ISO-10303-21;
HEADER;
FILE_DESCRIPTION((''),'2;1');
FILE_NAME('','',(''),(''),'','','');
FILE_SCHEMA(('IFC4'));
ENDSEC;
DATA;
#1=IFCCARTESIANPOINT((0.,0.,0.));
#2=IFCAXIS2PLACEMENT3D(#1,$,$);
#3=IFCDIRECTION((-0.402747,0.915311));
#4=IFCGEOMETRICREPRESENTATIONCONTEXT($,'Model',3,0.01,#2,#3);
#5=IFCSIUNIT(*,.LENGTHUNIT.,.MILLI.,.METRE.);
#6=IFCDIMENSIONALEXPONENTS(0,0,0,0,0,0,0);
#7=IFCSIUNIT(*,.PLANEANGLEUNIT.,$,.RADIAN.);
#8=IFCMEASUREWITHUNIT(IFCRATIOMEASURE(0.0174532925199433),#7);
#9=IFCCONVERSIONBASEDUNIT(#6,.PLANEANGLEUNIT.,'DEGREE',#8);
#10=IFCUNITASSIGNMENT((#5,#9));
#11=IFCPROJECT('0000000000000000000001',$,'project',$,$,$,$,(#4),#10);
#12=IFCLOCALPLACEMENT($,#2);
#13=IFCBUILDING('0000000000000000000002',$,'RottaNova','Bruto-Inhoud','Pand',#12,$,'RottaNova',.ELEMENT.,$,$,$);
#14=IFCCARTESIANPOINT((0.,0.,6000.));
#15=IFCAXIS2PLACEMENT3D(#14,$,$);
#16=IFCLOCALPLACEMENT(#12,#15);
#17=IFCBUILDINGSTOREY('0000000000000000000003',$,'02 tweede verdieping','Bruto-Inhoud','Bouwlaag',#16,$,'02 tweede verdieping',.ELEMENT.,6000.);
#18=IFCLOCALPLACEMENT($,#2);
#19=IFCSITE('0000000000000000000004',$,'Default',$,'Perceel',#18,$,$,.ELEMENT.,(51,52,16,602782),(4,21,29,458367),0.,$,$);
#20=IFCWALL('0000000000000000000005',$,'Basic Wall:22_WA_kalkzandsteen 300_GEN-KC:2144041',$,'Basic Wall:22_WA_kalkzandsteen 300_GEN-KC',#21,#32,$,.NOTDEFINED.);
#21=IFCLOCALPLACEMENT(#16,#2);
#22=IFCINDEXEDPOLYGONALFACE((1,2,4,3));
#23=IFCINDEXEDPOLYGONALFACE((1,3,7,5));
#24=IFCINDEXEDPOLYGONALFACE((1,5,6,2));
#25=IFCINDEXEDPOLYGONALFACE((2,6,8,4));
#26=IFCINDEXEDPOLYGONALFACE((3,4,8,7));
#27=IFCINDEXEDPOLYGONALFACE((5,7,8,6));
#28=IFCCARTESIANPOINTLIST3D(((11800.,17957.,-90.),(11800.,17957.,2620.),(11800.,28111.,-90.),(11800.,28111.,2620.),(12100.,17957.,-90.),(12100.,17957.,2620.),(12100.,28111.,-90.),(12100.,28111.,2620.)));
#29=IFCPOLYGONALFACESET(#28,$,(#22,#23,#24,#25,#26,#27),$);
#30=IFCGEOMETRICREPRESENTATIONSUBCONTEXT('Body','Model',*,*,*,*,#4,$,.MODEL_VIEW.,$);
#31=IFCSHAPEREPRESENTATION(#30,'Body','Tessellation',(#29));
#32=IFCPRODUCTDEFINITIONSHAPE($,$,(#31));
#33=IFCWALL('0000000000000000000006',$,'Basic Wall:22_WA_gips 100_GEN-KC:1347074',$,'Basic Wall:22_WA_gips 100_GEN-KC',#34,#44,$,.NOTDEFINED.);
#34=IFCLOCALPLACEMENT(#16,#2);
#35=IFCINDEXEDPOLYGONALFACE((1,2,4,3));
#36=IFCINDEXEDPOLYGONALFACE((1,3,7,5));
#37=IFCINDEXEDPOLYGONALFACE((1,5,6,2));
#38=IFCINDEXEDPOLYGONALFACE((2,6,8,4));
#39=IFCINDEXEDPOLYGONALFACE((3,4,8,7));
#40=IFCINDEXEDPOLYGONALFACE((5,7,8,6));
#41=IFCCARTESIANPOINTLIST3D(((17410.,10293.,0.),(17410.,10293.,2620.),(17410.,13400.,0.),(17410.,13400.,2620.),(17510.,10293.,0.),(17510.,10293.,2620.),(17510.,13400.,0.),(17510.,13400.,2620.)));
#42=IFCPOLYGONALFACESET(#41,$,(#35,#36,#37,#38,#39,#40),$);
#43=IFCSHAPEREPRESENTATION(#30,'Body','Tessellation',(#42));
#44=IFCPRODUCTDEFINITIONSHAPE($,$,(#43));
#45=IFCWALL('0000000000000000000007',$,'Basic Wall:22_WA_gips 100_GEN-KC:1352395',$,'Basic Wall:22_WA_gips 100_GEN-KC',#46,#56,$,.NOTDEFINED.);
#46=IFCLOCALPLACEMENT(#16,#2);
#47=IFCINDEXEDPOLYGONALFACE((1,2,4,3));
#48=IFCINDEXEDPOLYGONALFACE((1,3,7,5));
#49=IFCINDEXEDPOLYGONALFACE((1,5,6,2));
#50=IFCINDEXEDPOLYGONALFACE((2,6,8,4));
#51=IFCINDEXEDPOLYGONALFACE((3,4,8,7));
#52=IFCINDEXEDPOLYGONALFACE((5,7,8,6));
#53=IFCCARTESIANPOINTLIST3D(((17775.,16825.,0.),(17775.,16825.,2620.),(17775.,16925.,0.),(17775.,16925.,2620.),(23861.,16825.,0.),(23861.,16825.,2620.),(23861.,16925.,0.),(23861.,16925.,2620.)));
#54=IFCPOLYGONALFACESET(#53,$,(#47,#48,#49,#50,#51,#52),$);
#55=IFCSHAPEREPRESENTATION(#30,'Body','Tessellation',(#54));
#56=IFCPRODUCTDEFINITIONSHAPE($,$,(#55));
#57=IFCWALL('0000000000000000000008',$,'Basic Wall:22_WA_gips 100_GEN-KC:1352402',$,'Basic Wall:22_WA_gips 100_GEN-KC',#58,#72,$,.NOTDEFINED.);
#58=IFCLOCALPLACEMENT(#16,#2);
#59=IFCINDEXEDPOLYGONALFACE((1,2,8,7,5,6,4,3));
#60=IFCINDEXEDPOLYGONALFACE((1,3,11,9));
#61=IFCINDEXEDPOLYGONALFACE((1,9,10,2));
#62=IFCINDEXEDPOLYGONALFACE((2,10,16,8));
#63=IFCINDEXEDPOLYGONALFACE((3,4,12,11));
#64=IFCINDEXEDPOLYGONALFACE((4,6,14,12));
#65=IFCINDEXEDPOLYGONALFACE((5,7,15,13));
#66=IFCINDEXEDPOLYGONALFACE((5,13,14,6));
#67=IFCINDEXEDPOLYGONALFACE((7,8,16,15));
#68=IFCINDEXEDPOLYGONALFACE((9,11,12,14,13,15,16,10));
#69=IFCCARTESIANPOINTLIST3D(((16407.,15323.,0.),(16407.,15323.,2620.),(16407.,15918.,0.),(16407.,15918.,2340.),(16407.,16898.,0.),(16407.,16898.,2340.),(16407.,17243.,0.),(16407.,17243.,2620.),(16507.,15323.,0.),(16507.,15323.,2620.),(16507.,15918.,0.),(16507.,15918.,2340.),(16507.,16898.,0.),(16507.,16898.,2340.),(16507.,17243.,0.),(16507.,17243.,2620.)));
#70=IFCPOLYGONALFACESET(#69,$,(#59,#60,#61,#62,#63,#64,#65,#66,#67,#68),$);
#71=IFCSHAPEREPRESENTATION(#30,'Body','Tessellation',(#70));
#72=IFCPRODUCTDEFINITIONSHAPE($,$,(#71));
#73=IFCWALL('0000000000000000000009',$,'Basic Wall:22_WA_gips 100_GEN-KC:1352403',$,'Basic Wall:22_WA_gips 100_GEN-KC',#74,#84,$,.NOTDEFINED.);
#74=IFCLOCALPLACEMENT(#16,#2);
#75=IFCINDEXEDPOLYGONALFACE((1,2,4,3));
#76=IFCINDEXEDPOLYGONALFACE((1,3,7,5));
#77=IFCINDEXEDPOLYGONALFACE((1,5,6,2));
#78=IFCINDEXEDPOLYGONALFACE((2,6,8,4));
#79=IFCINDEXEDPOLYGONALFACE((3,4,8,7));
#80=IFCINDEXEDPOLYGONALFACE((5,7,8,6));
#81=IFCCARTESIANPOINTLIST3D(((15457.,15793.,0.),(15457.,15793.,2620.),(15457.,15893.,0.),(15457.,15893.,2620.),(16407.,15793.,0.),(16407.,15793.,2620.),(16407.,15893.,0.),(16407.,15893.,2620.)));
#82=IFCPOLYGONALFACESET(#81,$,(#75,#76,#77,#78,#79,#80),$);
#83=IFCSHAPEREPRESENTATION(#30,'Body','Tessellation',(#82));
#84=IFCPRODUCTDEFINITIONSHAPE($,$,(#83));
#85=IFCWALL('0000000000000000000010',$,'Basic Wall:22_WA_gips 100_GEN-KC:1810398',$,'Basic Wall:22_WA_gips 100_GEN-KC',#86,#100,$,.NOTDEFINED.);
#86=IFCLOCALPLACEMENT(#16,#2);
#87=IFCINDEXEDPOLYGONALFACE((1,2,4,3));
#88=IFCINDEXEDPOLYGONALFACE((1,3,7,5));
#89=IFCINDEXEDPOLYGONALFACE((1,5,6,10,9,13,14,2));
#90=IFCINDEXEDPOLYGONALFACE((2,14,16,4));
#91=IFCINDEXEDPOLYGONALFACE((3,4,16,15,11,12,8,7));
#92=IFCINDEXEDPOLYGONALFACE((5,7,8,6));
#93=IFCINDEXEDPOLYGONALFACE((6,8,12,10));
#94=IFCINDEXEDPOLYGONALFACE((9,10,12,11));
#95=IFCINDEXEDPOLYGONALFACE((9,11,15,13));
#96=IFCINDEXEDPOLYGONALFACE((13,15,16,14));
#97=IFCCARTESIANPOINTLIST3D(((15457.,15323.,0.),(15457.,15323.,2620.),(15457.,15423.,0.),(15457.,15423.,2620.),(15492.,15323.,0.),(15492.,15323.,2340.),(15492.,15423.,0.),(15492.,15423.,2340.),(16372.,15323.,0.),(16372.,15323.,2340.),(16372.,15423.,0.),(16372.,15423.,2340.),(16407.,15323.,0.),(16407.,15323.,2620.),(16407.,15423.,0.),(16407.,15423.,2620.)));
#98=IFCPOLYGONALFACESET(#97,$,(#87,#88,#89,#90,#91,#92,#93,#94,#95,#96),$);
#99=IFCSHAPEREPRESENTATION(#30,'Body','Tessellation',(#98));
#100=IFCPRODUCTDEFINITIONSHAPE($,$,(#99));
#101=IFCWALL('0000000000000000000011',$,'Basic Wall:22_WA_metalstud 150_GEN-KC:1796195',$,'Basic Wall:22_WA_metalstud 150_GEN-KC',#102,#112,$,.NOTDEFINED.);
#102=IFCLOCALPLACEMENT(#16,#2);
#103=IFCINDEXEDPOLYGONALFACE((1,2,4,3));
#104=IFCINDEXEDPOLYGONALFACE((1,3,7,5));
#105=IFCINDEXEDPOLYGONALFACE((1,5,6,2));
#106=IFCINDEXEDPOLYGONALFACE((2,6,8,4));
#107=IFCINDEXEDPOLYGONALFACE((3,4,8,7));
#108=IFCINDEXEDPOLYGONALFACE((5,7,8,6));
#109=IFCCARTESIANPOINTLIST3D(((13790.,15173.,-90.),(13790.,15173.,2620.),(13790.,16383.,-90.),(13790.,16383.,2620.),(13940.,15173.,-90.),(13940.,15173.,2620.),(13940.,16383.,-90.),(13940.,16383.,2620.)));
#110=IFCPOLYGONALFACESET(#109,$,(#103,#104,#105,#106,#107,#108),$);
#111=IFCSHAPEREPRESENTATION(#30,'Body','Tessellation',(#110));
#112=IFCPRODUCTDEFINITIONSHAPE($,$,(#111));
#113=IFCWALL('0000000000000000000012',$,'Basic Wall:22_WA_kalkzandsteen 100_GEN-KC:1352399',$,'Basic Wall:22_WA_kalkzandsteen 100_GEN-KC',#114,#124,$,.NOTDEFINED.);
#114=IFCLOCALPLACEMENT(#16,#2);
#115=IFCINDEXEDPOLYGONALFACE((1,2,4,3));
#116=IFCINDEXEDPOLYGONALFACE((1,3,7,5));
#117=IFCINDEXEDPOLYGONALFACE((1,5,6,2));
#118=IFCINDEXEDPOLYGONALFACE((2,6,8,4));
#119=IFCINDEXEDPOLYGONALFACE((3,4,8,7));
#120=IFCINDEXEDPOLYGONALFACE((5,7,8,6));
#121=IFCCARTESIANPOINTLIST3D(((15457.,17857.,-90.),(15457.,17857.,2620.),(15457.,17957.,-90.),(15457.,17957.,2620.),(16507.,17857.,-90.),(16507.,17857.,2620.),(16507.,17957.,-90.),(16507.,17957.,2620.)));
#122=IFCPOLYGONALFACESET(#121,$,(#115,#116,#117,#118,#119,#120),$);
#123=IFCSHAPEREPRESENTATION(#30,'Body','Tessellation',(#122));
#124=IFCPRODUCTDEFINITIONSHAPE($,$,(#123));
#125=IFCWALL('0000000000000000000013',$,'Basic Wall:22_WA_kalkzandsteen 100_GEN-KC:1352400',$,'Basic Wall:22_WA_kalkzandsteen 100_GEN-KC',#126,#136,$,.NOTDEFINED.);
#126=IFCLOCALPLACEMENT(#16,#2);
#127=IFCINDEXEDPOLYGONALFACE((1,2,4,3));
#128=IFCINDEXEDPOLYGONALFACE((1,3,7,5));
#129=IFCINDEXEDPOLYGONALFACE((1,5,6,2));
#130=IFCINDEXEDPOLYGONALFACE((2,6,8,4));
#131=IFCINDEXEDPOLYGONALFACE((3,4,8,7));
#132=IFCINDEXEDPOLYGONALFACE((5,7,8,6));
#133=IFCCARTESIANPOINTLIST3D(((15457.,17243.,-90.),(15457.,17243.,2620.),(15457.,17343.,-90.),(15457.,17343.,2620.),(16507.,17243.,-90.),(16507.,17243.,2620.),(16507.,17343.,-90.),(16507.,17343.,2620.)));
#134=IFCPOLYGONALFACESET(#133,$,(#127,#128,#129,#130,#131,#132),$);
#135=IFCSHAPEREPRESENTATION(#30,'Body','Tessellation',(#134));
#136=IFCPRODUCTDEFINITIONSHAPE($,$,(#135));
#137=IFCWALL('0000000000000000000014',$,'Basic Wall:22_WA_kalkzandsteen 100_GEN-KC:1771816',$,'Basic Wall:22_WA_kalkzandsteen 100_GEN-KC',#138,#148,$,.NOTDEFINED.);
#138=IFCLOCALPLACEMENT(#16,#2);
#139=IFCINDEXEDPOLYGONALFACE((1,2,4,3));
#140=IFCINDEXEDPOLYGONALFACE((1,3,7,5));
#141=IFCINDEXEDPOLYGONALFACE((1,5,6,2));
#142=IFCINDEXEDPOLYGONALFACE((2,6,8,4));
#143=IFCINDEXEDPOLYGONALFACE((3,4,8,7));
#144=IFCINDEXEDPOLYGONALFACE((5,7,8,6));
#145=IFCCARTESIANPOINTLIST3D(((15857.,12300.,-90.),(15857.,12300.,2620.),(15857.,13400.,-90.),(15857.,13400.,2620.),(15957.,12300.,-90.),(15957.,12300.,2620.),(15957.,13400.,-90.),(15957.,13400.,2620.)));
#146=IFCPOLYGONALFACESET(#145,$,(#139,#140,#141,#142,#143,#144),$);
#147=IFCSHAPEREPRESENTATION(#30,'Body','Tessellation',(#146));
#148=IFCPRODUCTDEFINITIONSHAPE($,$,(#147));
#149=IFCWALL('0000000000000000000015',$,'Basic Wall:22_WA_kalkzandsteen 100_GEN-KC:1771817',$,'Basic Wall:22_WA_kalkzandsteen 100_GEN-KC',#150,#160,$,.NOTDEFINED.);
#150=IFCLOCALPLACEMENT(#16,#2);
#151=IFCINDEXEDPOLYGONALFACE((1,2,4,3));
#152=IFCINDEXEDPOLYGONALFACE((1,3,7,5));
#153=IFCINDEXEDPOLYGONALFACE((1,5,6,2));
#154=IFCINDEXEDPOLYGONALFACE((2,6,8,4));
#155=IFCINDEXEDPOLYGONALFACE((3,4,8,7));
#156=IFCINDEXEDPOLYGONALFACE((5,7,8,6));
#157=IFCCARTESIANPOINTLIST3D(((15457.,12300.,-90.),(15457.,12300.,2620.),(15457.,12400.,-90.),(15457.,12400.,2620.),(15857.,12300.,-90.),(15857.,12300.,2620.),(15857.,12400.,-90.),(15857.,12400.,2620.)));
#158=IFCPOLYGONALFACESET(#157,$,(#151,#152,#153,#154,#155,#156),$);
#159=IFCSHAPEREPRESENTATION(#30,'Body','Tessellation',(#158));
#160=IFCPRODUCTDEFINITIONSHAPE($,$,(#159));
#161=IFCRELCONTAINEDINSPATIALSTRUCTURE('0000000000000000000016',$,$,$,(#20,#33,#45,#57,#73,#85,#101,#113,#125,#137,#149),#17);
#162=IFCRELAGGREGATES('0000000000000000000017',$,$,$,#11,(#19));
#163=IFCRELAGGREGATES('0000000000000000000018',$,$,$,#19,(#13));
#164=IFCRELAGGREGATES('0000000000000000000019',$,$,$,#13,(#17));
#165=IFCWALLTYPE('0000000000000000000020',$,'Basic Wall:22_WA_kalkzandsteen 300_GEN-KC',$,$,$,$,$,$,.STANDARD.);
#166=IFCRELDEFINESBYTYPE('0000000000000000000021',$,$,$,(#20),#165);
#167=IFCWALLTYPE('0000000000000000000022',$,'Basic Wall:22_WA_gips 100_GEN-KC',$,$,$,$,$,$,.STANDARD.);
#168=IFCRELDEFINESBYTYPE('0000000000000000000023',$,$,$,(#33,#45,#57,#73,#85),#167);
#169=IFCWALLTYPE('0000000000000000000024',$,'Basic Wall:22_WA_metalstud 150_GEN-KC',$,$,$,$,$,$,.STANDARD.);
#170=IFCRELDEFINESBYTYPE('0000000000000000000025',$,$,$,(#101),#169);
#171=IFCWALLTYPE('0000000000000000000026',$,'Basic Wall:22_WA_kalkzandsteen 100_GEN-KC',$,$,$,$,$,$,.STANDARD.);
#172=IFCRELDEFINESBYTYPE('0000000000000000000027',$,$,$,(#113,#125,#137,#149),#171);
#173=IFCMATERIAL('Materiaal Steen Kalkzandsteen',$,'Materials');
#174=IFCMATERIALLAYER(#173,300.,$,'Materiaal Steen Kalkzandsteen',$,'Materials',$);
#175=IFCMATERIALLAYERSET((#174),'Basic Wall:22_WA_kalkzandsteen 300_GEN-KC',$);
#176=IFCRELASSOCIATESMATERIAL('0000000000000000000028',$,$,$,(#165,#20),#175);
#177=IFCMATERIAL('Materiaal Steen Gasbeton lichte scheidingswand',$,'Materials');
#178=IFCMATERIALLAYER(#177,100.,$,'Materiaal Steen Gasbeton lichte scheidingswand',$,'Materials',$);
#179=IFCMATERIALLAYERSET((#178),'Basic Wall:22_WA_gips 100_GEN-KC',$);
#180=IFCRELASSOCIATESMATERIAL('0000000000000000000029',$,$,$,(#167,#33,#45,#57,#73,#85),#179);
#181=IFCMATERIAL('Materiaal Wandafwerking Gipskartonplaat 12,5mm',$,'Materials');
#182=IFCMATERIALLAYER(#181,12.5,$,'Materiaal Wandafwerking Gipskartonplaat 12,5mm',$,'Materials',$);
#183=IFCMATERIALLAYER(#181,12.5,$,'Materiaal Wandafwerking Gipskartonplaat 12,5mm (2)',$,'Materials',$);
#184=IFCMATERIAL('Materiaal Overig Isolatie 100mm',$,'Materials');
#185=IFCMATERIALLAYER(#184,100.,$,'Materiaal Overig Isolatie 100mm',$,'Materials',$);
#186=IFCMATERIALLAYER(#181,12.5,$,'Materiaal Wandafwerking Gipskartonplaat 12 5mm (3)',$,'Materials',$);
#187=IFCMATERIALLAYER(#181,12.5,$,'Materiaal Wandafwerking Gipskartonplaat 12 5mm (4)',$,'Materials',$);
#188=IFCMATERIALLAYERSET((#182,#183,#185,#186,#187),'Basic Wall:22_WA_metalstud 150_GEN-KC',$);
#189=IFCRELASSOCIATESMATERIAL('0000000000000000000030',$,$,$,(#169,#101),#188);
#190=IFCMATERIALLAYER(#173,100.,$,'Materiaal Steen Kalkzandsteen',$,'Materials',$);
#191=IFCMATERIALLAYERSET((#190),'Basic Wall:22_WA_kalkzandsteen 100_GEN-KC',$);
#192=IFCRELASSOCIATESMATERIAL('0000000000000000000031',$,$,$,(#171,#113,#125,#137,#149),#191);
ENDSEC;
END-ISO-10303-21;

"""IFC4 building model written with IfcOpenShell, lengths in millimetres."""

from ifc_helpers import new_model, entity, si_unit, converted_unit, direction, frame, frame_2d, origin, place, context, subcontext, project, spatial, rectangle, extrude, material, layer, layer_set, type_object, element, save


model = new_model("IFC4")

# Units and contexts
model_context = context("Model", 3, precision=0.01, world=origin(), true_north=direction((-0.402747, 0.915311)))
body_context = subcontext(model_context, "Body", "Model", "MODEL_VIEW")
ifc_project = project(units=[si_unit("LENGTHUNIT", "METRE", prefix="MILLI"), converted_unit("PLANEANGLEUNIT", "DEGREE", entity("IfcRatioMeasure", 0.0174532925199433), si_unit("PLANEANGLEUNIT", "RADIAN"), dimensions=[0, 0, 0, 0, 0, 0, 0])], contexts=[model_context])

# Site, building, storey
site_placement = place(None, origin())
site = spatial("IfcSite", under=ifc_project, at=site_placement, Name="Default", ObjectType="Perceel", CompositionType="ELEMENT", RefLatitude=(51, 52, 16, 602782), RefLongitude=(4, 21, 29, 458367), RefElevation=0.0)
building_placement = place(None, origin())
building = spatial("IfcBuilding", under=site, at=building_placement, Name="RottaNova", Description="Bruto-Inhoud", ObjectType="Pand", LongName="RottaNova", CompositionType="ELEMENT")
storey_placement = place(building_placement, frame((0.0, 0.0, 6000.0)))
storey = spatial("IfcBuildingStorey", under=building, at=storey_placement, Name="02 tweede verdieping", Description="Bruto-Inhoud", ObjectType="Bouwlaag", LongName="02 tweede verdieping", CompositionType="ELEMENT", Elevation=6000.0)

# Walls
ifc_material_1 = material(Name="Materiaal Steen Kalkzandsteen", Category="Materials")
ifc_layer_1 = layer(ifc_material_1, 300.0, Name="Materiaal Steen Kalkzandsteen", Category="Materials")
ifc_layer_set_1 = layer_set([ifc_layer_1], Name="Basic Wall:22_WA_kalkzandsteen 300_GEN-KC")
wall_type_1 = type_object("IfcWallType", Name="Basic Wall:22_WA_kalkzandsteen 300_GEN-KC", PredefinedType="STANDARD", material=ifc_layer_set_1)
wall_1_placement = place(storey_placement, frame((11950.0, 17957.0, -90.0), z_axis=(0.0, 0.0, 1.0), x_axis=(0.0, 1.0, 0.0)))
element("IfcWall", 1, at=wall_1_placement, inside=storey, type_object=wall_type_1, material=ifc_layer_set_1, Name="Basic Wall:22_WA_kalkzandsteen 300_GEN-KC:2144041", ObjectType="Basic Wall:22_WA_kalkzandsteen 300_GEN-KC", PredefinedType="NOTDEFINED", context=body_context, shape_type="SweptSolid", body=[
    extrude(rectangle(XDim=10154.0, YDim=300.0, at=frame_2d((5077.0, 0.0), x_axis=(-1.0, 0.0))), origin(), (0.0, 0.0, 1.0), 2710.0),
])
ifc_material_2 = material(Name="Materiaal Steen Gasbeton lichte scheidingswand", Category="Materials")
ifc_layer_2 = layer(ifc_material_2, 100.0, Name="Materiaal Steen Gasbeton lichte scheidingswand", Category="Materials")
ifc_layer_set_2 = layer_set([ifc_layer_2], Name="Basic Wall:22_WA_gips 100_GEN-KC")
wall_type_2 = type_object("IfcWallType", Name="Basic Wall:22_WA_gips 100_GEN-KC", PredefinedType="STANDARD", material=ifc_layer_set_2)
wall_2_placement = place(storey_placement, frame((17460.0, 13400.0, 0.0), z_axis=(0.0, 0.0, 1.0), x_axis=(0.0, -1.0, 0.0)))
element("IfcWall", 2, at=wall_2_placement, inside=storey, type_object=wall_type_2, material=ifc_layer_set_2, Name="Basic Wall:22_WA_gips 100_GEN-KC:1347074", ObjectType="Basic Wall:22_WA_gips 100_GEN-KC", PredefinedType="NOTDEFINED", context=body_context, shape_type="SweptSolid", body=[
    extrude(rectangle(XDim=3107.0, YDim=100.0, at=frame_2d((1553.5, 0.0), x_axis=(-1.0, 0.0))), origin(), (0.0, 0.0, 1.0), 2620.0),
])
wall_3_placement = place(storey_placement, frame((23861.0, 16875.0, 0.0), z_axis=(0.0, 0.0, 1.0), x_axis=(-1.0, 0.0, 0.0)))
element("IfcWall", 3, at=wall_3_placement, inside=storey, type_object=wall_type_2, material=ifc_layer_set_2, Name="Basic Wall:22_WA_gips 100_GEN-KC:1352395", ObjectType="Basic Wall:22_WA_gips 100_GEN-KC", PredefinedType="NOTDEFINED", context=body_context, shape_type="SweptSolid", body=[
    extrude(rectangle(XDim=6086.0, YDim=100.0, at=frame_2d((3043.0, 0.0), x_axis=(-1.0, 0.0))), origin(), (0.0, 0.0, 1.0), 2620.0),
])

# Wall, opening
wall_4_placement = place(storey_placement, frame((16457.0, 17243.0, 0.0), z_axis=(0.0, 0.0, 1.0), x_axis=(0.0, -1.0, 0.0)))
wall_4 = element("IfcWall", 4, at=wall_4_placement, inside=storey, type_object=wall_type_2, material=ifc_layer_set_2, Name="Basic Wall:22_WA_gips 100_GEN-KC:1352402", ObjectType="Basic Wall:22_WA_gips 100_GEN-KC", PredefinedType="NOTDEFINED", context=body_context, shape_type="SweptSolid", body=[
    extrude(rectangle(XDim=1920.0, YDim=100.0, at=frame_2d((960.0, 0.0), x_axis=(1.0, 0.0))), origin(), (0.0, 0.0, 1.0), 2620.0),
])
opening_1_placement = place(wall_4_placement, frame((345.0, -50.0, -90.0)))
element("IfcOpeningElement", 5, at=opening_1_placement, cuts=wall_4, PredefinedType="OPENING", context=body_context, shape_type="SweptSolid", body=[
    extrude(rectangle(XDim=2430.0, YDim=980.0, at=frame_2d((1215.0, 490.0), x_axis=(1.0, 0.0))), frame((0.0, 0.0, 0.0), z_axis=(0.0, 1.0, 0.0), x_axis=(0.0, 0.0, 1.0)), (0.0, 0.0, 1.0), 100.0),
])

# Wall
wall_5_placement = place(storey_placement, frame((16407.0, 15843.0, 0.0), z_axis=(0.0, 0.0, 1.0), x_axis=(-1.0, 0.0, 0.0)))
element("IfcWall", 6, at=wall_5_placement, inside=storey, type_object=wall_type_2, material=ifc_layer_set_2, Name="Basic Wall:22_WA_gips 100_GEN-KC:1352403", ObjectType="Basic Wall:22_WA_gips 100_GEN-KC", PredefinedType="NOTDEFINED", context=body_context, shape_type="SweptSolid", body=[
    extrude(rectangle(XDim=950.0, YDim=100.0, at=frame_2d((475.0, 0.0), x_axis=(-1.0, 0.0))), origin(), (0.0, 0.0, 1.0), 2620.0),
])

# Wall, opening
wall_6_placement = place(storey_placement, frame((16407.0, 15373.0, 0.0), z_axis=(0.0, 0.0, 1.0), x_axis=(-1.0, 0.0, 0.0)))
wall_6 = element("IfcWall", 7, at=wall_6_placement, inside=storey, type_object=wall_type_2, material=ifc_layer_set_2, Name="Basic Wall:22_WA_gips 100_GEN-KC:1810398", ObjectType="Basic Wall:22_WA_gips 100_GEN-KC", PredefinedType="NOTDEFINED", context=body_context, shape_type="SweptSolid", body=[
    extrude(rectangle(XDim=950.0, YDim=100.0, at=frame_2d((475.0, 0.0), x_axis=(1.0, 0.0))), origin(), (0.0, 0.0, 1.0), 2620.0),
])
opening_2_placement = place(wall_6_placement, frame((35.0, -50.0, -70.0)))
element("IfcOpeningElement", 8, at=opening_2_placement, cuts=wall_6, PredefinedType="OPENING", context=body_context, shape_type="SweptSolid", body=[
    extrude(rectangle(XDim=2410.0, YDim=880.0, at=frame_2d((1205.0, 440.0), x_axis=(1.0, 0.0))), frame((0.0, 0.0, 0.0), z_axis=(0.0, 1.0, 0.0), x_axis=(0.0, 0.0, 1.0)), (0.0, 0.0, 1.0), 100.0),
])

# Walls
ifc_material_3 = material(Name="Materiaal Wandafwerking Gipskartonplaat 12,5mm", Category="Materials")
ifc_layer_3 = layer(ifc_material_3, 12.5, Name="Materiaal Wandafwerking Gipskartonplaat 12,5mm", Category="Materials")
ifc_layer_4 = layer(ifc_material_3, 12.5, Name="Materiaal Wandafwerking Gipskartonplaat 12,5mm (2)", Category="Materials")
ifc_material_4 = material(Name="Materiaal Overig Isolatie 100mm", Category="Materials")
ifc_layer_5 = layer(ifc_material_4, 100.0, Name="Materiaal Overig Isolatie 100mm", Category="Materials")
ifc_layer_6 = layer(ifc_material_3, 12.5, Name="Materiaal Wandafwerking Gipskartonplaat 12 5mm (3)", Category="Materials")
ifc_layer_7 = layer(ifc_material_3, 12.5, Name="Materiaal Wandafwerking Gipskartonplaat 12 5mm (4)", Category="Materials")
ifc_layer_set_3 = layer_set([ifc_layer_3, ifc_layer_4, ifc_layer_5, ifc_layer_6, ifc_layer_7], Name="Basic Wall:22_WA_metalstud 150_GEN-KC")
wall_type_3 = type_object("IfcWallType", Name="Basic Wall:22_WA_metalstud 150_GEN-KC", PredefinedType="STANDARD", material=ifc_layer_set_3)
wall_7_placement = place(storey_placement, frame((13865.0, 15173.0, -90.0), z_axis=(0.0, 0.0, 1.0), x_axis=(0.0, 1.0, 0.0)))
element("IfcWall", 9, at=wall_7_placement, inside=storey, type_object=wall_type_3, material=ifc_layer_set_3, Name="Basic Wall:22_WA_metalstud 150_GEN-KC:1796195", ObjectType="Basic Wall:22_WA_metalstud 150_GEN-KC", PredefinedType="NOTDEFINED", context=body_context, shape_type="SweptSolid", body=[
    extrude(rectangle(XDim=1210.0, YDim=150.0, at=frame_2d((605.0, 0.0), x_axis=(-1.0, 0.0))), origin(), (0.0, 0.0, 1.0), 2710.0),
])
ifc_layer_8 = layer(ifc_material_1, 100.0, Name="Materiaal Steen Kalkzandsteen", Category="Materials")
ifc_layer_set_4 = layer_set([ifc_layer_8], Name="Basic Wall:22_WA_kalkzandsteen 100_GEN-KC")
wall_type_4 = type_object("IfcWallType", Name="Basic Wall:22_WA_kalkzandsteen 100_GEN-KC", PredefinedType="STANDARD", material=ifc_layer_set_4)
for number, where, z_axis, x_axis, name in (
    (10, (16507.0, 17907.0, -90.0), (0.0, 0.0, 1.0), (-1.0, 0.0, 0.0), "Basic Wall:22_WA_kalkzandsteen 100_GEN-KC:1352399"),
    (11, (16507.0, 17293.0, -90.0), (0.0, 0.0, 1.0), (-1.0, 0.0, 0.0), "Basic Wall:22_WA_kalkzandsteen 100_GEN-KC:1352400"),
):
    element("IfcWall", number, at=place(storey_placement, frame(where, z_axis=z_axis, x_axis=x_axis)), inside=storey, type_object=wall_type_4, material=ifc_layer_set_4, Name=name, ObjectType="Basic Wall:22_WA_kalkzandsteen 100_GEN-KC", PredefinedType="NOTDEFINED", context=body_context, shape_type="SweptSolid", body=[
        extrude(rectangle(XDim=1050.0, YDim=100.0, at=frame_2d((525.0, 0.0), x_axis=(-1.0, 0.0))), origin(), (0.0, 0.0, 1.0), 2710.0),
    ])
wall_8_placement = place(storey_placement, frame((15907.0, 13400.0, -90.0), z_axis=(0.0, 0.0, 1.0), x_axis=(0.0, -1.0, 0.0)))
element("IfcWall", 12, at=wall_8_placement, inside=storey, type_object=wall_type_4, material=ifc_layer_set_4, Name="Basic Wall:22_WA_kalkzandsteen 100_GEN-KC:1771816", ObjectType="Basic Wall:22_WA_kalkzandsteen 100_GEN-KC", PredefinedType="NOTDEFINED", context=body_context, shape_type="SweptSolid", body=[
    extrude(rectangle(XDim=1100.0, YDim=100.0, at=frame_2d((550.0, 0.0), x_axis=(-1.0, 0.0))), origin(), (0.0, 0.0, 1.0), 2710.0),
])
wall_9_placement = place(storey_placement, frame((15857.0, 12350.0, -90.0), z_axis=(0.0, 0.0, 1.0), x_axis=(-1.0, 0.0, 0.0)))
element("IfcWall", 13, at=wall_9_placement, inside=storey, type_object=wall_type_4, material=ifc_layer_set_4, Name="Basic Wall:22_WA_kalkzandsteen 100_GEN-KC:1771817", ObjectType="Basic Wall:22_WA_kalkzandsteen 100_GEN-KC", PredefinedType="NOTDEFINED", context=body_context, shape_type="SweptSolid", body=[
    extrude(rectangle(XDim=400.0, YDim=100.0, at=frame_2d((200.0, 0.0), x_axis=(-1.0, 0.0))), origin(), (0.0, 0.0, 1.0), 2710.0),
])

save(model, "model.ifc")
